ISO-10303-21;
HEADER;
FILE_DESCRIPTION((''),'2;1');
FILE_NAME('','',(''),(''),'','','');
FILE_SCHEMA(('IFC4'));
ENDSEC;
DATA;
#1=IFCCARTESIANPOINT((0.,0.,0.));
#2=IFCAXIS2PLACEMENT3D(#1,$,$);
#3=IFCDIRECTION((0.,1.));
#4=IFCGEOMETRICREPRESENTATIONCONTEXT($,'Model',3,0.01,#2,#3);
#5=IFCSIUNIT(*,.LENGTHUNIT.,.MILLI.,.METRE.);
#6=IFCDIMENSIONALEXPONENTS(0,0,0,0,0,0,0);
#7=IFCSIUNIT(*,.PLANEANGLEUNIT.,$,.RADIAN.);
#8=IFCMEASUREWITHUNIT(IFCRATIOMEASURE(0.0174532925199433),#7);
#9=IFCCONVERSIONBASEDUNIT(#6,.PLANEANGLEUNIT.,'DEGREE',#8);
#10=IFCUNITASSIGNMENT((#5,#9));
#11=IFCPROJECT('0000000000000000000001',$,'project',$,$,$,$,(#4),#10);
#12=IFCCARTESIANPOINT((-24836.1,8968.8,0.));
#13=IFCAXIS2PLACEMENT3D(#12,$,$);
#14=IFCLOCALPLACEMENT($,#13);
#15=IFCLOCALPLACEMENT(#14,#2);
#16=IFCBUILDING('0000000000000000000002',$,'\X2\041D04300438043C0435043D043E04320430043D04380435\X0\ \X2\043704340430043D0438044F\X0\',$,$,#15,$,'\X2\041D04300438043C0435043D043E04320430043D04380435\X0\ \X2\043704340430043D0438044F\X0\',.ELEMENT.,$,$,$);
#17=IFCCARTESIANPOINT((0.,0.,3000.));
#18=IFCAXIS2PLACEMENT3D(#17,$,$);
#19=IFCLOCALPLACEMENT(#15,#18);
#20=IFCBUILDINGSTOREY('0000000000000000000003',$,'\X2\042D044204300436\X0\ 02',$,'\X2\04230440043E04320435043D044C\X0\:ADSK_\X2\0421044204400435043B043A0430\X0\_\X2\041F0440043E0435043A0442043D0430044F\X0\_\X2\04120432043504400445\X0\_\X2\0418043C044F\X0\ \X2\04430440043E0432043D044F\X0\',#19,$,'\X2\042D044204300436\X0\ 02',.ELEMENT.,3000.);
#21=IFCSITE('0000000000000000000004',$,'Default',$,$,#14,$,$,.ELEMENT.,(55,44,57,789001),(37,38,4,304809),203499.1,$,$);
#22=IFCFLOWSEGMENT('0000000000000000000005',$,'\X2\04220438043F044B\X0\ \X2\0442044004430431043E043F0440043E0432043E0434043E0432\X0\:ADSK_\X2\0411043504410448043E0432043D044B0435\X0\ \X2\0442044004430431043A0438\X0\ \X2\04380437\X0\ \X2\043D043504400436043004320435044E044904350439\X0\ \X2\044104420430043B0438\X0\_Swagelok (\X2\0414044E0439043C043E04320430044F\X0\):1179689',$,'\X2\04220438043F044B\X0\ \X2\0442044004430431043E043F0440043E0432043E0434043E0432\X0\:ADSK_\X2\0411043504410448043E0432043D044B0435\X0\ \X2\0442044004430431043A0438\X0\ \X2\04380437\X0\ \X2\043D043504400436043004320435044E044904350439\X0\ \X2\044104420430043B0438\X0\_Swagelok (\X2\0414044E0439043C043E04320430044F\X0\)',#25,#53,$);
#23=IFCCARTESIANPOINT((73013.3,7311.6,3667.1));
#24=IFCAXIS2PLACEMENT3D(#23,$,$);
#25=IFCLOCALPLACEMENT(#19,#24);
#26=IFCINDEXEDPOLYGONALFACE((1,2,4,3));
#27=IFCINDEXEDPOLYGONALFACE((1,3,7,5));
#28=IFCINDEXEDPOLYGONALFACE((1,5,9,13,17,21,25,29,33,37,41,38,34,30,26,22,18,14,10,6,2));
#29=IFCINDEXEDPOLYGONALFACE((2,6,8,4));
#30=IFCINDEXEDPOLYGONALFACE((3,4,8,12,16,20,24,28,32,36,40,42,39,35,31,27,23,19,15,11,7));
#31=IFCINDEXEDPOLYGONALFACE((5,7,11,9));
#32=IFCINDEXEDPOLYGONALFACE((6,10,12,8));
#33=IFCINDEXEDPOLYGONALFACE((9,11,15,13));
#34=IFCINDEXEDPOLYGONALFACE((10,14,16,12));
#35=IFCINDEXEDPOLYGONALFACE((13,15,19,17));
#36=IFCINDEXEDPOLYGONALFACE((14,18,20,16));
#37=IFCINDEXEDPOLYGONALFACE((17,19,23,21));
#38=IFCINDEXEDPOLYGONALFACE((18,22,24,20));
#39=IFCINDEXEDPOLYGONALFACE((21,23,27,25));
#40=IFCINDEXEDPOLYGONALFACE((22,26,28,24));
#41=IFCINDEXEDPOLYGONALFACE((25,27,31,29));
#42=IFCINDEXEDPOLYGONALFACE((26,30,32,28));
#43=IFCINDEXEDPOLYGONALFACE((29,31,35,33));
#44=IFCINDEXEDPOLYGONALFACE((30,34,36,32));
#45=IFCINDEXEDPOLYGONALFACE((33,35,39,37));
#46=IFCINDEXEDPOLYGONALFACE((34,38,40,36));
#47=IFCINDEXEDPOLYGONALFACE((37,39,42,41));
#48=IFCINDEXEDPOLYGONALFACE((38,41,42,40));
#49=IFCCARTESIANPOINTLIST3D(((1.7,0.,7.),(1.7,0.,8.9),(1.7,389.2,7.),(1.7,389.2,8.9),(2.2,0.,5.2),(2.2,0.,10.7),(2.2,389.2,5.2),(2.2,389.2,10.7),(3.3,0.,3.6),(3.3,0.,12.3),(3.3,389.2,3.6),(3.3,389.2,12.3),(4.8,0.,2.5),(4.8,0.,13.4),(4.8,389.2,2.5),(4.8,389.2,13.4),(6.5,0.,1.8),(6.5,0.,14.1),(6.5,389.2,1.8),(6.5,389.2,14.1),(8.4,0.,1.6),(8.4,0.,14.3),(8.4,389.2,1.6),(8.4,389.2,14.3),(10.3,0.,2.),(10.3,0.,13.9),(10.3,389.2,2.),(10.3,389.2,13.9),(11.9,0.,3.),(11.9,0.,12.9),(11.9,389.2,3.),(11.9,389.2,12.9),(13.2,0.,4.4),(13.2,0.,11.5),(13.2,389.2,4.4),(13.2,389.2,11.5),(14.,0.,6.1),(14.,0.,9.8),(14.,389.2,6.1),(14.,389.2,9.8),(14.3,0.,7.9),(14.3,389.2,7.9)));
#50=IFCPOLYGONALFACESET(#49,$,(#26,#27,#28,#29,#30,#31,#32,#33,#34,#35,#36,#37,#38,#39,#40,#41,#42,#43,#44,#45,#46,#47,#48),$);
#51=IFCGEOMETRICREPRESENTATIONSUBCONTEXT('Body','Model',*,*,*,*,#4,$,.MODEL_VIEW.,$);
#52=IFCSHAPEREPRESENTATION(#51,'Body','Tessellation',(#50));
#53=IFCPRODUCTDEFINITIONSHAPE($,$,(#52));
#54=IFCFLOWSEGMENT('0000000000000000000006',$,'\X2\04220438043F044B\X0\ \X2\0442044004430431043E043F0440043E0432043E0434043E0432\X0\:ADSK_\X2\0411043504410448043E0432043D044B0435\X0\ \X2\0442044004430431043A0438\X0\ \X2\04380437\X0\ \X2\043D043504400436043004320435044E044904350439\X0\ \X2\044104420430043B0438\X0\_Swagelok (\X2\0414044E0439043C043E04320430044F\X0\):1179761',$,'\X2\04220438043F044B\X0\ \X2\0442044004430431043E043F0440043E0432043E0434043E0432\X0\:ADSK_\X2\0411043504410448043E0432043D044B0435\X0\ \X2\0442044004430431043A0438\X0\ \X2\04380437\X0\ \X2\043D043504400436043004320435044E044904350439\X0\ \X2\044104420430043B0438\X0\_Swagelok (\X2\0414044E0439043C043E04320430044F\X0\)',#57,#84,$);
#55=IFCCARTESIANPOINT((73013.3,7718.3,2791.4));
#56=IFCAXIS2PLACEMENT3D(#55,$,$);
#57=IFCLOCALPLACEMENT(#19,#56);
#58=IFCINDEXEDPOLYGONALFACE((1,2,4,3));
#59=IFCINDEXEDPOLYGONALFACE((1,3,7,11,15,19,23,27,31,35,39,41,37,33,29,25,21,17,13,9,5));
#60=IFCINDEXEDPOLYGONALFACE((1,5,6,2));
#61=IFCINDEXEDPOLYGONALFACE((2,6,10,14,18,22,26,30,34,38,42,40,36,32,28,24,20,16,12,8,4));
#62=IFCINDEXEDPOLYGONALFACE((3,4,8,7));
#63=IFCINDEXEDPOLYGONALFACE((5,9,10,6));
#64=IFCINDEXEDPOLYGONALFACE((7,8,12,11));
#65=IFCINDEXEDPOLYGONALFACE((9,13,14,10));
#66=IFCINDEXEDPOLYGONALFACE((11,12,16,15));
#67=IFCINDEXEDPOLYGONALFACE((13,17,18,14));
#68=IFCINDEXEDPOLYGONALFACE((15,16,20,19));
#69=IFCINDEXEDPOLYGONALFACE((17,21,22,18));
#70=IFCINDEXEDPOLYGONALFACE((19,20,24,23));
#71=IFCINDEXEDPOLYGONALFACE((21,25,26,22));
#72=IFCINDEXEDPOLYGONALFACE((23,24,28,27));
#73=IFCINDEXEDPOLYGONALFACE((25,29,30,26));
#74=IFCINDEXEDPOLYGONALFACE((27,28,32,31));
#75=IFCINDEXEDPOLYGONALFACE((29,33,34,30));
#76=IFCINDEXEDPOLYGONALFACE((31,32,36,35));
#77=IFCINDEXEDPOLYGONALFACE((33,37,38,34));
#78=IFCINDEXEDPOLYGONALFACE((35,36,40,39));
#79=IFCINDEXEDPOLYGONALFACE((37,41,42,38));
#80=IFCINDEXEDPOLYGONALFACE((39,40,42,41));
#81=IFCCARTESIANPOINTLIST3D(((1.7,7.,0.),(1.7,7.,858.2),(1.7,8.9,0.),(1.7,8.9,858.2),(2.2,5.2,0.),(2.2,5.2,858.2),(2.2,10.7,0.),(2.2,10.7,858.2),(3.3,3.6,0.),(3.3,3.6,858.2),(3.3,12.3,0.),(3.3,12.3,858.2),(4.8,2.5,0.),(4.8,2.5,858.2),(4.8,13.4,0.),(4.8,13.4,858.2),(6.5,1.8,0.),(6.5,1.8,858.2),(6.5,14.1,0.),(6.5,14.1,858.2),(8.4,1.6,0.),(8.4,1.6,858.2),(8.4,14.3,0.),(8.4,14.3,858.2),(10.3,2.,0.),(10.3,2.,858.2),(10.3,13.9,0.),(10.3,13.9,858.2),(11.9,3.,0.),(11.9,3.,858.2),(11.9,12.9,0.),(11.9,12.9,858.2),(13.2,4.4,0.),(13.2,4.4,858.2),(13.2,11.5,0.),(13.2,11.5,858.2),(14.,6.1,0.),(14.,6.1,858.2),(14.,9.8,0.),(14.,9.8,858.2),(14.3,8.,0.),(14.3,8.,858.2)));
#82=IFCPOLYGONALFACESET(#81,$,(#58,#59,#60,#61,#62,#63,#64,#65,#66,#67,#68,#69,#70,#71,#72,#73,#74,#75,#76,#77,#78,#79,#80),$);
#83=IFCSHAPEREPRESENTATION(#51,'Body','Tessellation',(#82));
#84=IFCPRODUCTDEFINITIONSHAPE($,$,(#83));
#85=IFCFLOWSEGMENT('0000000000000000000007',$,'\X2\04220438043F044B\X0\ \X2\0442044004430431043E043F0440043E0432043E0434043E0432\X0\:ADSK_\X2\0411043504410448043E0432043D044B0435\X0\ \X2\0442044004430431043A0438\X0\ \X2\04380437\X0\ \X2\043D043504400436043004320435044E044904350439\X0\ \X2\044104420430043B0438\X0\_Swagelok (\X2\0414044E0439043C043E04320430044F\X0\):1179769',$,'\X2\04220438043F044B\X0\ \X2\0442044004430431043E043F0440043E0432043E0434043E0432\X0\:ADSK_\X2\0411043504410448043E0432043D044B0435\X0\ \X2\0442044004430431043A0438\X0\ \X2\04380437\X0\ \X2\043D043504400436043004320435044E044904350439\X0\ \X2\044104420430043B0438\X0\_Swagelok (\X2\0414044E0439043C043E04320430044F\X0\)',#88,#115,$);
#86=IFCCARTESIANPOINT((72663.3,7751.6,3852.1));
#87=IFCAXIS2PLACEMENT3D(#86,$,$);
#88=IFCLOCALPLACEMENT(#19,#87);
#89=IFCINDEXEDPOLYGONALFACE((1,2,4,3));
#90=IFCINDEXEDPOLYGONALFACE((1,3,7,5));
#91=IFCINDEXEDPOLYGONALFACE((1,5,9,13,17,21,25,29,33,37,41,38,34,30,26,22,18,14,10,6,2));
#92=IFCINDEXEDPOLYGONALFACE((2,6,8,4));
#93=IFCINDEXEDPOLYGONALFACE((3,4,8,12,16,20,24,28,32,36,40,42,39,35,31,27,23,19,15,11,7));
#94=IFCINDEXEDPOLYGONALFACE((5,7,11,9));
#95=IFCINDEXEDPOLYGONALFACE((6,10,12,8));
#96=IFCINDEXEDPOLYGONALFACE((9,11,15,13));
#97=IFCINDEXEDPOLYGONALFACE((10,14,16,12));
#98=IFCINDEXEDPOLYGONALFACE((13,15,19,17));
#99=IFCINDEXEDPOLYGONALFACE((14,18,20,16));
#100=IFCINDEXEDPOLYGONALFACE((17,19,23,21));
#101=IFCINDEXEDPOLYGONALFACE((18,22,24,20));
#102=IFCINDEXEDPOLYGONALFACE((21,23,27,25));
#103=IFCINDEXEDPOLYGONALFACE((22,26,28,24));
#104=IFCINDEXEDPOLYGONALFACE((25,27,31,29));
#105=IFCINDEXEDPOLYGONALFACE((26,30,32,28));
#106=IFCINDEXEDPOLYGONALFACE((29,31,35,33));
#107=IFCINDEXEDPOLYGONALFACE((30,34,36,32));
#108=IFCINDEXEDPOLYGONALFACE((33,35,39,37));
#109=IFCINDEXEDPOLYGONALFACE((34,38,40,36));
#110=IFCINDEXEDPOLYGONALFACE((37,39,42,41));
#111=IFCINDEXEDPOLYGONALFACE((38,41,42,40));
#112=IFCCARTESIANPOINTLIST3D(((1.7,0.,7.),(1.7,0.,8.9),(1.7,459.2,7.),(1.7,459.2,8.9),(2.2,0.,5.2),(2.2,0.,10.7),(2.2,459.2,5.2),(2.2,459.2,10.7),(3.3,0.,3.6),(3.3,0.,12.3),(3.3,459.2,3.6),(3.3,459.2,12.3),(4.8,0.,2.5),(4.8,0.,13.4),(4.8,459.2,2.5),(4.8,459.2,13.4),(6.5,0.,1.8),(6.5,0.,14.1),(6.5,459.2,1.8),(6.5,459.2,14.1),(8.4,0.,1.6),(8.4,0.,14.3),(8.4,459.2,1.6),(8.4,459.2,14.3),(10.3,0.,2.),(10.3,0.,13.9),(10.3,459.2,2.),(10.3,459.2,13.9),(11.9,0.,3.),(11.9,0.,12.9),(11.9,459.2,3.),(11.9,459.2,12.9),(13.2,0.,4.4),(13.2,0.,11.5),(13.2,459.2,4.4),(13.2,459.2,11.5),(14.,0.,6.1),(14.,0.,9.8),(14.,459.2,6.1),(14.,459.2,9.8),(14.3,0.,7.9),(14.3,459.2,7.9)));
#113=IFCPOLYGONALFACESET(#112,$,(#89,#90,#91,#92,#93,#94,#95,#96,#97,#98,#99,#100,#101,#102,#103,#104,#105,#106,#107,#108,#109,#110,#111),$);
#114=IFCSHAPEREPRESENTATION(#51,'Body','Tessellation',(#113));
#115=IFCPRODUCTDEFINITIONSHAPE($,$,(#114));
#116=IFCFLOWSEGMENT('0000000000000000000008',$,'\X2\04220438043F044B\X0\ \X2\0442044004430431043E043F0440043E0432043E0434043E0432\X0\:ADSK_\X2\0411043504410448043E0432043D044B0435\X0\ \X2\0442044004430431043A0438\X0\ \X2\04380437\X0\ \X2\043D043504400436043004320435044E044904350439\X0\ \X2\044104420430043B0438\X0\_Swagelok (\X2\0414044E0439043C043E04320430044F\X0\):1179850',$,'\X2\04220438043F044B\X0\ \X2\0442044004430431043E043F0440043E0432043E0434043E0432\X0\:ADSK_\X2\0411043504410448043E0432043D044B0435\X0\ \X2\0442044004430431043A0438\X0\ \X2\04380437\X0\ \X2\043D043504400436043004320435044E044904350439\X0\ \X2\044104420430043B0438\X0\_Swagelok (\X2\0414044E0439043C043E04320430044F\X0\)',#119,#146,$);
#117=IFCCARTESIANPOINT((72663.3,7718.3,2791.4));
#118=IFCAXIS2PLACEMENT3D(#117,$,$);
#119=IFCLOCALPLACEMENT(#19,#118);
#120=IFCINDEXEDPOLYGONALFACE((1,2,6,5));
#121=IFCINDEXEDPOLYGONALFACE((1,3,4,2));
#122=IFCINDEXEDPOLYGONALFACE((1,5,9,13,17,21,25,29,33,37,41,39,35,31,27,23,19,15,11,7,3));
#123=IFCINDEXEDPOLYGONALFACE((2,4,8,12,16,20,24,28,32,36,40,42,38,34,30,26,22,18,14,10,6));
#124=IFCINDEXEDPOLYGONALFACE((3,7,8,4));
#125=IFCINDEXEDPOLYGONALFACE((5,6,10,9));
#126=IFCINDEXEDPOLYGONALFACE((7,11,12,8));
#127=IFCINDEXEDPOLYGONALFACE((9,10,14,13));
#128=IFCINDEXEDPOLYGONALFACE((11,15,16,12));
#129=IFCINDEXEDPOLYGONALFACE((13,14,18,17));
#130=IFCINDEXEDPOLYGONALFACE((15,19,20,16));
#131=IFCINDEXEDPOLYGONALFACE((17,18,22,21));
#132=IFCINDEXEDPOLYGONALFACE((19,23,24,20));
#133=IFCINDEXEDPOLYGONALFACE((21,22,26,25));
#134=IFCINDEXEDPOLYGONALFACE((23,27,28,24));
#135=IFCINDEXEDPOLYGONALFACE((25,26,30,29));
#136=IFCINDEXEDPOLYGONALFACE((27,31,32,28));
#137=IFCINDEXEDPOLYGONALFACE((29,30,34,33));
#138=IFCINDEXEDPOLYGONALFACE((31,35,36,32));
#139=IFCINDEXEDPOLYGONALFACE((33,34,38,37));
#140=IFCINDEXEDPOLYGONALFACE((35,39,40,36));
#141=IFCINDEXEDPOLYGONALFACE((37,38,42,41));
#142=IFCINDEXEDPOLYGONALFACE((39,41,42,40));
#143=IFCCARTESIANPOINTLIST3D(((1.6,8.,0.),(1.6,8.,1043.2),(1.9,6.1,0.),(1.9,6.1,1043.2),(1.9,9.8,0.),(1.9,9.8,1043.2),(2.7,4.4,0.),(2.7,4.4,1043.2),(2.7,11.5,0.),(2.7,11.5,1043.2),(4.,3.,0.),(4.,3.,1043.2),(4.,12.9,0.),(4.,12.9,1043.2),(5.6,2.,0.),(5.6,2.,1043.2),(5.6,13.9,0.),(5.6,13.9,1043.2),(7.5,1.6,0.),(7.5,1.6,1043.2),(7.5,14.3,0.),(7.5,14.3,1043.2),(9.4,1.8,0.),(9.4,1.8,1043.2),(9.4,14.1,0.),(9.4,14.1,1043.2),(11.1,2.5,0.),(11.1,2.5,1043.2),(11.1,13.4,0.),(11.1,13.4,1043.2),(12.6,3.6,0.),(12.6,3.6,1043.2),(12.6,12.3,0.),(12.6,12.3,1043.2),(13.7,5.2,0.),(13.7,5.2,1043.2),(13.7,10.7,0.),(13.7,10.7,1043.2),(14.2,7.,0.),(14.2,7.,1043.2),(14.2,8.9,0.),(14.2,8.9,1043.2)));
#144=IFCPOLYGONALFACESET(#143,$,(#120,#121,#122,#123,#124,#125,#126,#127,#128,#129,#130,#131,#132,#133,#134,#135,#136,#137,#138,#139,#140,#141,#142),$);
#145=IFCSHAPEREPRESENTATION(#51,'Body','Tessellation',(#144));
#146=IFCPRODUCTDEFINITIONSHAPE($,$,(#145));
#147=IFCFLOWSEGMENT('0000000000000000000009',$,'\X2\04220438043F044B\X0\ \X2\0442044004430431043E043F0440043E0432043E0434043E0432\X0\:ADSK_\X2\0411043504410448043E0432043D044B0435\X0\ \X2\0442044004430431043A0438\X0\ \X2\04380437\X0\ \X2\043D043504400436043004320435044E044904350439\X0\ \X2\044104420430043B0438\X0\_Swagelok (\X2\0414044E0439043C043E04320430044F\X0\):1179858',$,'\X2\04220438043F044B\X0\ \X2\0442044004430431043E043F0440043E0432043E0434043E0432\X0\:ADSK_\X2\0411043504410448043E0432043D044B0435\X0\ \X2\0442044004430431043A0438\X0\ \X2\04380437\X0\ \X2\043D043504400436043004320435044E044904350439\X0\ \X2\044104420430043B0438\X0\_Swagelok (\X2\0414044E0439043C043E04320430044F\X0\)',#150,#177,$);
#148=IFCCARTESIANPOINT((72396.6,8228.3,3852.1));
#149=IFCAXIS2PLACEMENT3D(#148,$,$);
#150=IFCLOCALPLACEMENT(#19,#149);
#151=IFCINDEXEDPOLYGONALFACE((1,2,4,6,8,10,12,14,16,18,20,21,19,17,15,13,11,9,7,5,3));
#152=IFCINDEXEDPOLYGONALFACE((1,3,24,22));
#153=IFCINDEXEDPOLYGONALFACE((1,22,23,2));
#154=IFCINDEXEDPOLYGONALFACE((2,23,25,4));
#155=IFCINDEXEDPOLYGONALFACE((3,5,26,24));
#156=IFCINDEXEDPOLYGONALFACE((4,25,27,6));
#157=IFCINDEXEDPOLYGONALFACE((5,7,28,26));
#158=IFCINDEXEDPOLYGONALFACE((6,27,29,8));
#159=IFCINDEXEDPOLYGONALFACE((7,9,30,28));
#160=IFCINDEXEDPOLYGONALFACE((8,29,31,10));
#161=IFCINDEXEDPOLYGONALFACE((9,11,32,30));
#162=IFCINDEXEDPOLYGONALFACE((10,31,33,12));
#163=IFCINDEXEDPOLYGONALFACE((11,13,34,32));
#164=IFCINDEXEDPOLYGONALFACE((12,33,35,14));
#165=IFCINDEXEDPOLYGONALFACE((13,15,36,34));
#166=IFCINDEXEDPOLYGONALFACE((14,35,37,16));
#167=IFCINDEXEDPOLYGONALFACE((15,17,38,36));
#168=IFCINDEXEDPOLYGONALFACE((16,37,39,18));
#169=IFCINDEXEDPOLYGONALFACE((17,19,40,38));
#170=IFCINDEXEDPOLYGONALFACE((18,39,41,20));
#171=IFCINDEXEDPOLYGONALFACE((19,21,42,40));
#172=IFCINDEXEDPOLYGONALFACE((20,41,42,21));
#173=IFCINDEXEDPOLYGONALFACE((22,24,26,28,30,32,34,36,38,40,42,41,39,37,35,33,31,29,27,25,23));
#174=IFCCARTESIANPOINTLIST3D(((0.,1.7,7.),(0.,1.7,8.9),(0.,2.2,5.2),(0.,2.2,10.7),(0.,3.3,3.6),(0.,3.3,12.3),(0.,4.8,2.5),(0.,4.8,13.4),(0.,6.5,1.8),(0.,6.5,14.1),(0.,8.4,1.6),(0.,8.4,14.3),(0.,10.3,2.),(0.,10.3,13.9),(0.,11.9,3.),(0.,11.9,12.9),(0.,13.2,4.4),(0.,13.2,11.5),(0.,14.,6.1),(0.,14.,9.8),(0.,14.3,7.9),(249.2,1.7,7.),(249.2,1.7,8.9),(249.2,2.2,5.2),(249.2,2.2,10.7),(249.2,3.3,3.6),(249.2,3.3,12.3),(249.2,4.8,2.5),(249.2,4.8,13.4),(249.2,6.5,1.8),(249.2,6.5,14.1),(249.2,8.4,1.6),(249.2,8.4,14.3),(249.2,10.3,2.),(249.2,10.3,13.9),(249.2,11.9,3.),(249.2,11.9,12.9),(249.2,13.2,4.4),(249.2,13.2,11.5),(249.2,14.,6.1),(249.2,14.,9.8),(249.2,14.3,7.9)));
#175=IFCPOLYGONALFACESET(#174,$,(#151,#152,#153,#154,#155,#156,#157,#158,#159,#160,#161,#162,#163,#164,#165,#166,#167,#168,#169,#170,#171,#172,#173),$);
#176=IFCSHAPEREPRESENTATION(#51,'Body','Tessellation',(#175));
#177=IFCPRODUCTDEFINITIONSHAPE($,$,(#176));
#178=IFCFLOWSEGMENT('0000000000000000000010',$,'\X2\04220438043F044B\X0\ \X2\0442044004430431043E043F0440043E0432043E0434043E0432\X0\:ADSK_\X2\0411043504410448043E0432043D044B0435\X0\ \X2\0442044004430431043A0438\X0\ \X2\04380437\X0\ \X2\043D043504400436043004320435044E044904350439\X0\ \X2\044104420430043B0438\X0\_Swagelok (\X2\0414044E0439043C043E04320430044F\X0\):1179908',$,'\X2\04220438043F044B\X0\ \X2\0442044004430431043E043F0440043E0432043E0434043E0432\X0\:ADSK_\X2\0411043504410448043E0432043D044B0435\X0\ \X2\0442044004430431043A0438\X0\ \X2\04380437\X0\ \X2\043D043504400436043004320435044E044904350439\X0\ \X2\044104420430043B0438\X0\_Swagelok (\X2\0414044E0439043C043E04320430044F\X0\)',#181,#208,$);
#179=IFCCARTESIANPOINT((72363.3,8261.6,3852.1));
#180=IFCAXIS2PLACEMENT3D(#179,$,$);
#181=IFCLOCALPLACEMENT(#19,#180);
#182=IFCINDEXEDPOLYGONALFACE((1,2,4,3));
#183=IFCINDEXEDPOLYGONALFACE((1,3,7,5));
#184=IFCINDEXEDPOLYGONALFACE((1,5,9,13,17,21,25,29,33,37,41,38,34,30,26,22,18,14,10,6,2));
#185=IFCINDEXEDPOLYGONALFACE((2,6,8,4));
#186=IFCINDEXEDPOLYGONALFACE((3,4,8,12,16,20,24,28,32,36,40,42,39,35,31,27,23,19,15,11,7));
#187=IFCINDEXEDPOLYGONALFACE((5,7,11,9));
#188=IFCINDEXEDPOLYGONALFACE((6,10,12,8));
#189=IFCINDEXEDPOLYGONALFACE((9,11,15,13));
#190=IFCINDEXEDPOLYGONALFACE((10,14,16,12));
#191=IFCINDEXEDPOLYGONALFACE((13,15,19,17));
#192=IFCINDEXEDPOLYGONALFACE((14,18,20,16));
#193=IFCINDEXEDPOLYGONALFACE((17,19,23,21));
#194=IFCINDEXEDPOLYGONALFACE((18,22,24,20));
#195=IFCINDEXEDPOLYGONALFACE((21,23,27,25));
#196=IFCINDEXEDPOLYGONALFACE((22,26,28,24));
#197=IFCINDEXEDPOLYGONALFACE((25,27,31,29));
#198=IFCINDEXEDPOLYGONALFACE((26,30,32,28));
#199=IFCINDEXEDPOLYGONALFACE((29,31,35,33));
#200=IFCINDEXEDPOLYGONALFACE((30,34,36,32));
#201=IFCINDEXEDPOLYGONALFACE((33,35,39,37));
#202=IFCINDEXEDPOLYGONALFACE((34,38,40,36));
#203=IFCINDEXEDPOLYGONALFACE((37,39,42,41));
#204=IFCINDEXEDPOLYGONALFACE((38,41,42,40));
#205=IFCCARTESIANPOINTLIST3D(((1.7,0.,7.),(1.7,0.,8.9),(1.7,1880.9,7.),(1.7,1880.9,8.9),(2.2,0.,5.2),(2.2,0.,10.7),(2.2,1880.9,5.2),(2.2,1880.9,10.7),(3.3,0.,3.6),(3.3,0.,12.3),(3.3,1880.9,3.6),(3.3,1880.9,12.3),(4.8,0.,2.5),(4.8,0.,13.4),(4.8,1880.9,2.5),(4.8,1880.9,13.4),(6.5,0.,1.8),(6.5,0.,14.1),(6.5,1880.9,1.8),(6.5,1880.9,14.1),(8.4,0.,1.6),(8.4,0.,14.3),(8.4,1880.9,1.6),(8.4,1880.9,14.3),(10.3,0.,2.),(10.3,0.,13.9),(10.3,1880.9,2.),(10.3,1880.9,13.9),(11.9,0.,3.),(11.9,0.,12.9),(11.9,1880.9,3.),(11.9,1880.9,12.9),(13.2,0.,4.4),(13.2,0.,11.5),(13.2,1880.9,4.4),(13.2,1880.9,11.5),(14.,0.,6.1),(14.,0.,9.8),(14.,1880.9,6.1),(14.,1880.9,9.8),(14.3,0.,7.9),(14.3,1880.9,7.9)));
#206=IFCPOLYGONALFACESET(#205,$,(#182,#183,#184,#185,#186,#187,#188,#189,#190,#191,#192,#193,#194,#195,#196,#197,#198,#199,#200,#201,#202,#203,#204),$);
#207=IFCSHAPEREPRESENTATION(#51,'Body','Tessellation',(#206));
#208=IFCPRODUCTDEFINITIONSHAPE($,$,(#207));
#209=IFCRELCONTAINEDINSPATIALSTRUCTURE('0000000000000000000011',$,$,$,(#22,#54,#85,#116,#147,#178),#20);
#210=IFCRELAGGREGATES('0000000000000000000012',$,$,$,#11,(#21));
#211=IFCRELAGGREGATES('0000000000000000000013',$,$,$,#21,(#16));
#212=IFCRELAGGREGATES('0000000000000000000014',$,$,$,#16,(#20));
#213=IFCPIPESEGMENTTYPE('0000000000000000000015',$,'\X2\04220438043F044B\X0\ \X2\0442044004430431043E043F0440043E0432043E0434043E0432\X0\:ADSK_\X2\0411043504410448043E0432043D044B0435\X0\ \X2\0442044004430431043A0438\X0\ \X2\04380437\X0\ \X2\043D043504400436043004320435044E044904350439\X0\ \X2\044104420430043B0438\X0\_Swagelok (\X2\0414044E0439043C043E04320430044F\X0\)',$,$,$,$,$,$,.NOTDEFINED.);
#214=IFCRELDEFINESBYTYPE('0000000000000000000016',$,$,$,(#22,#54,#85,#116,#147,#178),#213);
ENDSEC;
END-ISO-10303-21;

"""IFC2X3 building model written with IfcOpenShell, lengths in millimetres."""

from ifc_helpers import new_model, entity, si_unit, converted_unit, direction, frame, origin, origin_2d_with_axis, place, context, subcontext, project, spatial, circle, extrude, type_object, element, save


model = new_model("IFC2X3")

# Units and contexts
model_context = context("Model", 3, precision=0.01, world=origin(), true_north=direction((0.0, 1.0)))
body_context = subcontext(model_context, "Body", "Model", "MODEL_VIEW")
ifc_project = project(units=[si_unit("LENGTHUNIT", "METRE", prefix="MILLI"), converted_unit("PLANEANGLEUNIT", "DEGREE", entity("IfcRatioMeasure", 0.0174532925199433), si_unit("PLANEANGLEUNIT", "RADIAN"), dimensions=[0, 0, 0, 0, 0, 0, 0])], contexts=[model_context])

# Site, building, storey
site_placement = place(None, frame((-24836.1, 8968.8, 0.0)))
site = spatial("IfcSite", under=ifc_project, at=site_placement, Name="Default", CompositionType="ELEMENT", RefLatitude=(55, 44, 57, 789001), RefLongitude=(37, 38, 4, 304809), RefElevation=203499.1)
building_placement = place(site_placement, origin())
building = spatial("IfcBuilding", under=site, at=building_placement, Name="Наименование здания", LongName="Наименование здания", CompositionType="ELEMENT")
storey_placement = place(building_placement, frame((0.0, 0.0, 3000.0)))
storey = spatial("IfcBuildingStorey", under=building, at=storey_placement, Name="Этаж 02", ObjectType="Уровень:ADSK_Стрелка_Проектная_Вверх_Имя уровня", LongName="Этаж 02", CompositionType="ELEMENT", Elevation=3000.0)

# Flow segments
pipe_segment_type_1 = type_object("IfcPipeSegmentType", Name="Типы трубопроводов:ADSK_Бесшовные трубки из нержавеющей стали_Swagelok (Дюймовая)", PredefinedType="NOTDEFINED")
flow_segment_1_placement = place(storey_placement, frame((73013.3, 7311.6, 3667.1)))
element("IfcFlowSegment", 1, at=flow_segment_1_placement, inside=storey, type_object=pipe_segment_type_1, Name="Типы трубопроводов:ADSK_Бесшовные трубки из нержавеющей стали_Swagelok (Дюймовая):1179689", ObjectType="Типы трубопроводов:ADSK_Бесшовные трубки из нержавеющей стали_Swagelok (Дюймовая)", context=body_context, shape_type="SweptSolid", body=[
    extrude(circle(Radius=6.3, at=origin_2d_with_axis()), frame((8.0, 0.0, 8.0), z_axis=(0.0, 1.0, 0.0), x_axis=(1.0, 0.0, 0.0)), (0.0, 0.0, 1.0), 389.2),
])
flow_segment_2_placement = place(storey_placement, frame((73013.3, 7718.3, 2791.4)))
element("IfcFlowSegment", 2, at=flow_segment_2_placement, inside=storey, type_object=pipe_segment_type_1, Name="Типы трубопроводов:ADSK_Бесшовные трубки из нержавеющей стали_Swagelok (Дюймовая):1179761", ObjectType="Типы трубопроводов:ADSK_Бесшовные трубки из нержавеющей стали_Swagelok (Дюймовая)", context=body_context, shape_type="SweptSolid", body=[
    extrude(circle(Radius=6.3, at=origin_2d_with_axis()), frame((8.0, 8.0, 0.0)), (0.0, 0.0, 1.0), 858.2),
])
flow_segment_3_placement = place(storey_placement, frame((72663.3, 7751.6, 3852.1)))
element("IfcFlowSegment", 3, at=flow_segment_3_placement, inside=storey, type_object=pipe_segment_type_1, Name="Типы трубопроводов:ADSK_Бесшовные трубки из нержавеющей стали_Swagelok (Дюймовая):1179769", ObjectType="Типы трубопроводов:ADSK_Бесшовные трубки из нержавеющей стали_Swagelok (Дюймовая)", context=body_context, shape_type="SweptSolid", body=[
    extrude(circle(Radius=6.3, at=origin_2d_with_axis()), frame((8.0, 0.0, 8.0), z_axis=(0.0, 1.0, 0.0), x_axis=(1.0, 0.0, 0.0)), (0.0, 0.0, 1.0), 459.2),
])
flow_segment_4_placement = place(storey_placement, frame((72663.3, 7718.3, 2791.4)))
element("IfcFlowSegment", 4, at=flow_segment_4_placement, inside=storey, type_object=pipe_segment_type_1, Name="Типы трубопроводов:ADSK_Бесшовные трубки из нержавеющей стали_Swagelok (Дюймовая):1179850", ObjectType="Типы трубопроводов:ADSK_Бесшовные трубки из нержавеющей стали_Swagelok (Дюймовая)", context=body_context, shape_type="SweptSolid", body=[
    extrude(circle(Radius=6.3, at=origin_2d_with_axis()), frame((8.0, 8.0, 0.0), z_axis=(0.0, 0.0, 1.0), x_axis=(-1.0, 0.0, 0.0)), (0.0, 0.0, 1.0), 1043.2),
])
flow_segment_5_placement = place(storey_placement, frame((72396.6, 8228.3, 3852.1)))
element("IfcFlowSegment", 5, at=flow_segment_5_placement, inside=storey, type_object=pipe_segment_type_1, Name="Типы трубопроводов:ADSK_Бесшовные трубки из нержавеющей стали_Swagelok (Дюймовая):1179858", ObjectType="Типы трубопроводов:ADSK_Бесшовные трубки из нержавеющей стали_Swagelok (Дюймовая)", context=body_context, shape_type="SweptSolid", body=[
    extrude(circle(Radius=6.3, at=origin_2d_with_axis()), frame((0.0, 8.0, 8.0), z_axis=(1.0, 0.0, 0.0), x_axis=(0.0, 1.0, 0.0)), (0.0, 0.0, 1.0), 249.2),
])
flow_segment_6_placement = place(storey_placement, frame((72363.3, 8261.6, 3852.1)))
element("IfcFlowSegment", 6, at=flow_segment_6_placement, inside=storey, type_object=pipe_segment_type_1, Name="Типы трубопроводов:ADSK_Бесшовные трубки из нержавеющей стали_Swagelok (Дюймовая):1179908", ObjectType="Типы трубопроводов:ADSK_Бесшовные трубки из нержавеющей стали_Swagelok (Дюймовая)", context=body_context, shape_type="SweptSolid", body=[
    extrude(circle(Radius=6.3, at=origin_2d_with_axis()), frame((8.0, 0.0, 8.0), z_axis=(0.0, 1.0, 0.0), x_axis=(1.0, 0.0, 0.0)), (0.0, 0.0, 1.0), 1880.9),
])

save(model, "model.ifc")
